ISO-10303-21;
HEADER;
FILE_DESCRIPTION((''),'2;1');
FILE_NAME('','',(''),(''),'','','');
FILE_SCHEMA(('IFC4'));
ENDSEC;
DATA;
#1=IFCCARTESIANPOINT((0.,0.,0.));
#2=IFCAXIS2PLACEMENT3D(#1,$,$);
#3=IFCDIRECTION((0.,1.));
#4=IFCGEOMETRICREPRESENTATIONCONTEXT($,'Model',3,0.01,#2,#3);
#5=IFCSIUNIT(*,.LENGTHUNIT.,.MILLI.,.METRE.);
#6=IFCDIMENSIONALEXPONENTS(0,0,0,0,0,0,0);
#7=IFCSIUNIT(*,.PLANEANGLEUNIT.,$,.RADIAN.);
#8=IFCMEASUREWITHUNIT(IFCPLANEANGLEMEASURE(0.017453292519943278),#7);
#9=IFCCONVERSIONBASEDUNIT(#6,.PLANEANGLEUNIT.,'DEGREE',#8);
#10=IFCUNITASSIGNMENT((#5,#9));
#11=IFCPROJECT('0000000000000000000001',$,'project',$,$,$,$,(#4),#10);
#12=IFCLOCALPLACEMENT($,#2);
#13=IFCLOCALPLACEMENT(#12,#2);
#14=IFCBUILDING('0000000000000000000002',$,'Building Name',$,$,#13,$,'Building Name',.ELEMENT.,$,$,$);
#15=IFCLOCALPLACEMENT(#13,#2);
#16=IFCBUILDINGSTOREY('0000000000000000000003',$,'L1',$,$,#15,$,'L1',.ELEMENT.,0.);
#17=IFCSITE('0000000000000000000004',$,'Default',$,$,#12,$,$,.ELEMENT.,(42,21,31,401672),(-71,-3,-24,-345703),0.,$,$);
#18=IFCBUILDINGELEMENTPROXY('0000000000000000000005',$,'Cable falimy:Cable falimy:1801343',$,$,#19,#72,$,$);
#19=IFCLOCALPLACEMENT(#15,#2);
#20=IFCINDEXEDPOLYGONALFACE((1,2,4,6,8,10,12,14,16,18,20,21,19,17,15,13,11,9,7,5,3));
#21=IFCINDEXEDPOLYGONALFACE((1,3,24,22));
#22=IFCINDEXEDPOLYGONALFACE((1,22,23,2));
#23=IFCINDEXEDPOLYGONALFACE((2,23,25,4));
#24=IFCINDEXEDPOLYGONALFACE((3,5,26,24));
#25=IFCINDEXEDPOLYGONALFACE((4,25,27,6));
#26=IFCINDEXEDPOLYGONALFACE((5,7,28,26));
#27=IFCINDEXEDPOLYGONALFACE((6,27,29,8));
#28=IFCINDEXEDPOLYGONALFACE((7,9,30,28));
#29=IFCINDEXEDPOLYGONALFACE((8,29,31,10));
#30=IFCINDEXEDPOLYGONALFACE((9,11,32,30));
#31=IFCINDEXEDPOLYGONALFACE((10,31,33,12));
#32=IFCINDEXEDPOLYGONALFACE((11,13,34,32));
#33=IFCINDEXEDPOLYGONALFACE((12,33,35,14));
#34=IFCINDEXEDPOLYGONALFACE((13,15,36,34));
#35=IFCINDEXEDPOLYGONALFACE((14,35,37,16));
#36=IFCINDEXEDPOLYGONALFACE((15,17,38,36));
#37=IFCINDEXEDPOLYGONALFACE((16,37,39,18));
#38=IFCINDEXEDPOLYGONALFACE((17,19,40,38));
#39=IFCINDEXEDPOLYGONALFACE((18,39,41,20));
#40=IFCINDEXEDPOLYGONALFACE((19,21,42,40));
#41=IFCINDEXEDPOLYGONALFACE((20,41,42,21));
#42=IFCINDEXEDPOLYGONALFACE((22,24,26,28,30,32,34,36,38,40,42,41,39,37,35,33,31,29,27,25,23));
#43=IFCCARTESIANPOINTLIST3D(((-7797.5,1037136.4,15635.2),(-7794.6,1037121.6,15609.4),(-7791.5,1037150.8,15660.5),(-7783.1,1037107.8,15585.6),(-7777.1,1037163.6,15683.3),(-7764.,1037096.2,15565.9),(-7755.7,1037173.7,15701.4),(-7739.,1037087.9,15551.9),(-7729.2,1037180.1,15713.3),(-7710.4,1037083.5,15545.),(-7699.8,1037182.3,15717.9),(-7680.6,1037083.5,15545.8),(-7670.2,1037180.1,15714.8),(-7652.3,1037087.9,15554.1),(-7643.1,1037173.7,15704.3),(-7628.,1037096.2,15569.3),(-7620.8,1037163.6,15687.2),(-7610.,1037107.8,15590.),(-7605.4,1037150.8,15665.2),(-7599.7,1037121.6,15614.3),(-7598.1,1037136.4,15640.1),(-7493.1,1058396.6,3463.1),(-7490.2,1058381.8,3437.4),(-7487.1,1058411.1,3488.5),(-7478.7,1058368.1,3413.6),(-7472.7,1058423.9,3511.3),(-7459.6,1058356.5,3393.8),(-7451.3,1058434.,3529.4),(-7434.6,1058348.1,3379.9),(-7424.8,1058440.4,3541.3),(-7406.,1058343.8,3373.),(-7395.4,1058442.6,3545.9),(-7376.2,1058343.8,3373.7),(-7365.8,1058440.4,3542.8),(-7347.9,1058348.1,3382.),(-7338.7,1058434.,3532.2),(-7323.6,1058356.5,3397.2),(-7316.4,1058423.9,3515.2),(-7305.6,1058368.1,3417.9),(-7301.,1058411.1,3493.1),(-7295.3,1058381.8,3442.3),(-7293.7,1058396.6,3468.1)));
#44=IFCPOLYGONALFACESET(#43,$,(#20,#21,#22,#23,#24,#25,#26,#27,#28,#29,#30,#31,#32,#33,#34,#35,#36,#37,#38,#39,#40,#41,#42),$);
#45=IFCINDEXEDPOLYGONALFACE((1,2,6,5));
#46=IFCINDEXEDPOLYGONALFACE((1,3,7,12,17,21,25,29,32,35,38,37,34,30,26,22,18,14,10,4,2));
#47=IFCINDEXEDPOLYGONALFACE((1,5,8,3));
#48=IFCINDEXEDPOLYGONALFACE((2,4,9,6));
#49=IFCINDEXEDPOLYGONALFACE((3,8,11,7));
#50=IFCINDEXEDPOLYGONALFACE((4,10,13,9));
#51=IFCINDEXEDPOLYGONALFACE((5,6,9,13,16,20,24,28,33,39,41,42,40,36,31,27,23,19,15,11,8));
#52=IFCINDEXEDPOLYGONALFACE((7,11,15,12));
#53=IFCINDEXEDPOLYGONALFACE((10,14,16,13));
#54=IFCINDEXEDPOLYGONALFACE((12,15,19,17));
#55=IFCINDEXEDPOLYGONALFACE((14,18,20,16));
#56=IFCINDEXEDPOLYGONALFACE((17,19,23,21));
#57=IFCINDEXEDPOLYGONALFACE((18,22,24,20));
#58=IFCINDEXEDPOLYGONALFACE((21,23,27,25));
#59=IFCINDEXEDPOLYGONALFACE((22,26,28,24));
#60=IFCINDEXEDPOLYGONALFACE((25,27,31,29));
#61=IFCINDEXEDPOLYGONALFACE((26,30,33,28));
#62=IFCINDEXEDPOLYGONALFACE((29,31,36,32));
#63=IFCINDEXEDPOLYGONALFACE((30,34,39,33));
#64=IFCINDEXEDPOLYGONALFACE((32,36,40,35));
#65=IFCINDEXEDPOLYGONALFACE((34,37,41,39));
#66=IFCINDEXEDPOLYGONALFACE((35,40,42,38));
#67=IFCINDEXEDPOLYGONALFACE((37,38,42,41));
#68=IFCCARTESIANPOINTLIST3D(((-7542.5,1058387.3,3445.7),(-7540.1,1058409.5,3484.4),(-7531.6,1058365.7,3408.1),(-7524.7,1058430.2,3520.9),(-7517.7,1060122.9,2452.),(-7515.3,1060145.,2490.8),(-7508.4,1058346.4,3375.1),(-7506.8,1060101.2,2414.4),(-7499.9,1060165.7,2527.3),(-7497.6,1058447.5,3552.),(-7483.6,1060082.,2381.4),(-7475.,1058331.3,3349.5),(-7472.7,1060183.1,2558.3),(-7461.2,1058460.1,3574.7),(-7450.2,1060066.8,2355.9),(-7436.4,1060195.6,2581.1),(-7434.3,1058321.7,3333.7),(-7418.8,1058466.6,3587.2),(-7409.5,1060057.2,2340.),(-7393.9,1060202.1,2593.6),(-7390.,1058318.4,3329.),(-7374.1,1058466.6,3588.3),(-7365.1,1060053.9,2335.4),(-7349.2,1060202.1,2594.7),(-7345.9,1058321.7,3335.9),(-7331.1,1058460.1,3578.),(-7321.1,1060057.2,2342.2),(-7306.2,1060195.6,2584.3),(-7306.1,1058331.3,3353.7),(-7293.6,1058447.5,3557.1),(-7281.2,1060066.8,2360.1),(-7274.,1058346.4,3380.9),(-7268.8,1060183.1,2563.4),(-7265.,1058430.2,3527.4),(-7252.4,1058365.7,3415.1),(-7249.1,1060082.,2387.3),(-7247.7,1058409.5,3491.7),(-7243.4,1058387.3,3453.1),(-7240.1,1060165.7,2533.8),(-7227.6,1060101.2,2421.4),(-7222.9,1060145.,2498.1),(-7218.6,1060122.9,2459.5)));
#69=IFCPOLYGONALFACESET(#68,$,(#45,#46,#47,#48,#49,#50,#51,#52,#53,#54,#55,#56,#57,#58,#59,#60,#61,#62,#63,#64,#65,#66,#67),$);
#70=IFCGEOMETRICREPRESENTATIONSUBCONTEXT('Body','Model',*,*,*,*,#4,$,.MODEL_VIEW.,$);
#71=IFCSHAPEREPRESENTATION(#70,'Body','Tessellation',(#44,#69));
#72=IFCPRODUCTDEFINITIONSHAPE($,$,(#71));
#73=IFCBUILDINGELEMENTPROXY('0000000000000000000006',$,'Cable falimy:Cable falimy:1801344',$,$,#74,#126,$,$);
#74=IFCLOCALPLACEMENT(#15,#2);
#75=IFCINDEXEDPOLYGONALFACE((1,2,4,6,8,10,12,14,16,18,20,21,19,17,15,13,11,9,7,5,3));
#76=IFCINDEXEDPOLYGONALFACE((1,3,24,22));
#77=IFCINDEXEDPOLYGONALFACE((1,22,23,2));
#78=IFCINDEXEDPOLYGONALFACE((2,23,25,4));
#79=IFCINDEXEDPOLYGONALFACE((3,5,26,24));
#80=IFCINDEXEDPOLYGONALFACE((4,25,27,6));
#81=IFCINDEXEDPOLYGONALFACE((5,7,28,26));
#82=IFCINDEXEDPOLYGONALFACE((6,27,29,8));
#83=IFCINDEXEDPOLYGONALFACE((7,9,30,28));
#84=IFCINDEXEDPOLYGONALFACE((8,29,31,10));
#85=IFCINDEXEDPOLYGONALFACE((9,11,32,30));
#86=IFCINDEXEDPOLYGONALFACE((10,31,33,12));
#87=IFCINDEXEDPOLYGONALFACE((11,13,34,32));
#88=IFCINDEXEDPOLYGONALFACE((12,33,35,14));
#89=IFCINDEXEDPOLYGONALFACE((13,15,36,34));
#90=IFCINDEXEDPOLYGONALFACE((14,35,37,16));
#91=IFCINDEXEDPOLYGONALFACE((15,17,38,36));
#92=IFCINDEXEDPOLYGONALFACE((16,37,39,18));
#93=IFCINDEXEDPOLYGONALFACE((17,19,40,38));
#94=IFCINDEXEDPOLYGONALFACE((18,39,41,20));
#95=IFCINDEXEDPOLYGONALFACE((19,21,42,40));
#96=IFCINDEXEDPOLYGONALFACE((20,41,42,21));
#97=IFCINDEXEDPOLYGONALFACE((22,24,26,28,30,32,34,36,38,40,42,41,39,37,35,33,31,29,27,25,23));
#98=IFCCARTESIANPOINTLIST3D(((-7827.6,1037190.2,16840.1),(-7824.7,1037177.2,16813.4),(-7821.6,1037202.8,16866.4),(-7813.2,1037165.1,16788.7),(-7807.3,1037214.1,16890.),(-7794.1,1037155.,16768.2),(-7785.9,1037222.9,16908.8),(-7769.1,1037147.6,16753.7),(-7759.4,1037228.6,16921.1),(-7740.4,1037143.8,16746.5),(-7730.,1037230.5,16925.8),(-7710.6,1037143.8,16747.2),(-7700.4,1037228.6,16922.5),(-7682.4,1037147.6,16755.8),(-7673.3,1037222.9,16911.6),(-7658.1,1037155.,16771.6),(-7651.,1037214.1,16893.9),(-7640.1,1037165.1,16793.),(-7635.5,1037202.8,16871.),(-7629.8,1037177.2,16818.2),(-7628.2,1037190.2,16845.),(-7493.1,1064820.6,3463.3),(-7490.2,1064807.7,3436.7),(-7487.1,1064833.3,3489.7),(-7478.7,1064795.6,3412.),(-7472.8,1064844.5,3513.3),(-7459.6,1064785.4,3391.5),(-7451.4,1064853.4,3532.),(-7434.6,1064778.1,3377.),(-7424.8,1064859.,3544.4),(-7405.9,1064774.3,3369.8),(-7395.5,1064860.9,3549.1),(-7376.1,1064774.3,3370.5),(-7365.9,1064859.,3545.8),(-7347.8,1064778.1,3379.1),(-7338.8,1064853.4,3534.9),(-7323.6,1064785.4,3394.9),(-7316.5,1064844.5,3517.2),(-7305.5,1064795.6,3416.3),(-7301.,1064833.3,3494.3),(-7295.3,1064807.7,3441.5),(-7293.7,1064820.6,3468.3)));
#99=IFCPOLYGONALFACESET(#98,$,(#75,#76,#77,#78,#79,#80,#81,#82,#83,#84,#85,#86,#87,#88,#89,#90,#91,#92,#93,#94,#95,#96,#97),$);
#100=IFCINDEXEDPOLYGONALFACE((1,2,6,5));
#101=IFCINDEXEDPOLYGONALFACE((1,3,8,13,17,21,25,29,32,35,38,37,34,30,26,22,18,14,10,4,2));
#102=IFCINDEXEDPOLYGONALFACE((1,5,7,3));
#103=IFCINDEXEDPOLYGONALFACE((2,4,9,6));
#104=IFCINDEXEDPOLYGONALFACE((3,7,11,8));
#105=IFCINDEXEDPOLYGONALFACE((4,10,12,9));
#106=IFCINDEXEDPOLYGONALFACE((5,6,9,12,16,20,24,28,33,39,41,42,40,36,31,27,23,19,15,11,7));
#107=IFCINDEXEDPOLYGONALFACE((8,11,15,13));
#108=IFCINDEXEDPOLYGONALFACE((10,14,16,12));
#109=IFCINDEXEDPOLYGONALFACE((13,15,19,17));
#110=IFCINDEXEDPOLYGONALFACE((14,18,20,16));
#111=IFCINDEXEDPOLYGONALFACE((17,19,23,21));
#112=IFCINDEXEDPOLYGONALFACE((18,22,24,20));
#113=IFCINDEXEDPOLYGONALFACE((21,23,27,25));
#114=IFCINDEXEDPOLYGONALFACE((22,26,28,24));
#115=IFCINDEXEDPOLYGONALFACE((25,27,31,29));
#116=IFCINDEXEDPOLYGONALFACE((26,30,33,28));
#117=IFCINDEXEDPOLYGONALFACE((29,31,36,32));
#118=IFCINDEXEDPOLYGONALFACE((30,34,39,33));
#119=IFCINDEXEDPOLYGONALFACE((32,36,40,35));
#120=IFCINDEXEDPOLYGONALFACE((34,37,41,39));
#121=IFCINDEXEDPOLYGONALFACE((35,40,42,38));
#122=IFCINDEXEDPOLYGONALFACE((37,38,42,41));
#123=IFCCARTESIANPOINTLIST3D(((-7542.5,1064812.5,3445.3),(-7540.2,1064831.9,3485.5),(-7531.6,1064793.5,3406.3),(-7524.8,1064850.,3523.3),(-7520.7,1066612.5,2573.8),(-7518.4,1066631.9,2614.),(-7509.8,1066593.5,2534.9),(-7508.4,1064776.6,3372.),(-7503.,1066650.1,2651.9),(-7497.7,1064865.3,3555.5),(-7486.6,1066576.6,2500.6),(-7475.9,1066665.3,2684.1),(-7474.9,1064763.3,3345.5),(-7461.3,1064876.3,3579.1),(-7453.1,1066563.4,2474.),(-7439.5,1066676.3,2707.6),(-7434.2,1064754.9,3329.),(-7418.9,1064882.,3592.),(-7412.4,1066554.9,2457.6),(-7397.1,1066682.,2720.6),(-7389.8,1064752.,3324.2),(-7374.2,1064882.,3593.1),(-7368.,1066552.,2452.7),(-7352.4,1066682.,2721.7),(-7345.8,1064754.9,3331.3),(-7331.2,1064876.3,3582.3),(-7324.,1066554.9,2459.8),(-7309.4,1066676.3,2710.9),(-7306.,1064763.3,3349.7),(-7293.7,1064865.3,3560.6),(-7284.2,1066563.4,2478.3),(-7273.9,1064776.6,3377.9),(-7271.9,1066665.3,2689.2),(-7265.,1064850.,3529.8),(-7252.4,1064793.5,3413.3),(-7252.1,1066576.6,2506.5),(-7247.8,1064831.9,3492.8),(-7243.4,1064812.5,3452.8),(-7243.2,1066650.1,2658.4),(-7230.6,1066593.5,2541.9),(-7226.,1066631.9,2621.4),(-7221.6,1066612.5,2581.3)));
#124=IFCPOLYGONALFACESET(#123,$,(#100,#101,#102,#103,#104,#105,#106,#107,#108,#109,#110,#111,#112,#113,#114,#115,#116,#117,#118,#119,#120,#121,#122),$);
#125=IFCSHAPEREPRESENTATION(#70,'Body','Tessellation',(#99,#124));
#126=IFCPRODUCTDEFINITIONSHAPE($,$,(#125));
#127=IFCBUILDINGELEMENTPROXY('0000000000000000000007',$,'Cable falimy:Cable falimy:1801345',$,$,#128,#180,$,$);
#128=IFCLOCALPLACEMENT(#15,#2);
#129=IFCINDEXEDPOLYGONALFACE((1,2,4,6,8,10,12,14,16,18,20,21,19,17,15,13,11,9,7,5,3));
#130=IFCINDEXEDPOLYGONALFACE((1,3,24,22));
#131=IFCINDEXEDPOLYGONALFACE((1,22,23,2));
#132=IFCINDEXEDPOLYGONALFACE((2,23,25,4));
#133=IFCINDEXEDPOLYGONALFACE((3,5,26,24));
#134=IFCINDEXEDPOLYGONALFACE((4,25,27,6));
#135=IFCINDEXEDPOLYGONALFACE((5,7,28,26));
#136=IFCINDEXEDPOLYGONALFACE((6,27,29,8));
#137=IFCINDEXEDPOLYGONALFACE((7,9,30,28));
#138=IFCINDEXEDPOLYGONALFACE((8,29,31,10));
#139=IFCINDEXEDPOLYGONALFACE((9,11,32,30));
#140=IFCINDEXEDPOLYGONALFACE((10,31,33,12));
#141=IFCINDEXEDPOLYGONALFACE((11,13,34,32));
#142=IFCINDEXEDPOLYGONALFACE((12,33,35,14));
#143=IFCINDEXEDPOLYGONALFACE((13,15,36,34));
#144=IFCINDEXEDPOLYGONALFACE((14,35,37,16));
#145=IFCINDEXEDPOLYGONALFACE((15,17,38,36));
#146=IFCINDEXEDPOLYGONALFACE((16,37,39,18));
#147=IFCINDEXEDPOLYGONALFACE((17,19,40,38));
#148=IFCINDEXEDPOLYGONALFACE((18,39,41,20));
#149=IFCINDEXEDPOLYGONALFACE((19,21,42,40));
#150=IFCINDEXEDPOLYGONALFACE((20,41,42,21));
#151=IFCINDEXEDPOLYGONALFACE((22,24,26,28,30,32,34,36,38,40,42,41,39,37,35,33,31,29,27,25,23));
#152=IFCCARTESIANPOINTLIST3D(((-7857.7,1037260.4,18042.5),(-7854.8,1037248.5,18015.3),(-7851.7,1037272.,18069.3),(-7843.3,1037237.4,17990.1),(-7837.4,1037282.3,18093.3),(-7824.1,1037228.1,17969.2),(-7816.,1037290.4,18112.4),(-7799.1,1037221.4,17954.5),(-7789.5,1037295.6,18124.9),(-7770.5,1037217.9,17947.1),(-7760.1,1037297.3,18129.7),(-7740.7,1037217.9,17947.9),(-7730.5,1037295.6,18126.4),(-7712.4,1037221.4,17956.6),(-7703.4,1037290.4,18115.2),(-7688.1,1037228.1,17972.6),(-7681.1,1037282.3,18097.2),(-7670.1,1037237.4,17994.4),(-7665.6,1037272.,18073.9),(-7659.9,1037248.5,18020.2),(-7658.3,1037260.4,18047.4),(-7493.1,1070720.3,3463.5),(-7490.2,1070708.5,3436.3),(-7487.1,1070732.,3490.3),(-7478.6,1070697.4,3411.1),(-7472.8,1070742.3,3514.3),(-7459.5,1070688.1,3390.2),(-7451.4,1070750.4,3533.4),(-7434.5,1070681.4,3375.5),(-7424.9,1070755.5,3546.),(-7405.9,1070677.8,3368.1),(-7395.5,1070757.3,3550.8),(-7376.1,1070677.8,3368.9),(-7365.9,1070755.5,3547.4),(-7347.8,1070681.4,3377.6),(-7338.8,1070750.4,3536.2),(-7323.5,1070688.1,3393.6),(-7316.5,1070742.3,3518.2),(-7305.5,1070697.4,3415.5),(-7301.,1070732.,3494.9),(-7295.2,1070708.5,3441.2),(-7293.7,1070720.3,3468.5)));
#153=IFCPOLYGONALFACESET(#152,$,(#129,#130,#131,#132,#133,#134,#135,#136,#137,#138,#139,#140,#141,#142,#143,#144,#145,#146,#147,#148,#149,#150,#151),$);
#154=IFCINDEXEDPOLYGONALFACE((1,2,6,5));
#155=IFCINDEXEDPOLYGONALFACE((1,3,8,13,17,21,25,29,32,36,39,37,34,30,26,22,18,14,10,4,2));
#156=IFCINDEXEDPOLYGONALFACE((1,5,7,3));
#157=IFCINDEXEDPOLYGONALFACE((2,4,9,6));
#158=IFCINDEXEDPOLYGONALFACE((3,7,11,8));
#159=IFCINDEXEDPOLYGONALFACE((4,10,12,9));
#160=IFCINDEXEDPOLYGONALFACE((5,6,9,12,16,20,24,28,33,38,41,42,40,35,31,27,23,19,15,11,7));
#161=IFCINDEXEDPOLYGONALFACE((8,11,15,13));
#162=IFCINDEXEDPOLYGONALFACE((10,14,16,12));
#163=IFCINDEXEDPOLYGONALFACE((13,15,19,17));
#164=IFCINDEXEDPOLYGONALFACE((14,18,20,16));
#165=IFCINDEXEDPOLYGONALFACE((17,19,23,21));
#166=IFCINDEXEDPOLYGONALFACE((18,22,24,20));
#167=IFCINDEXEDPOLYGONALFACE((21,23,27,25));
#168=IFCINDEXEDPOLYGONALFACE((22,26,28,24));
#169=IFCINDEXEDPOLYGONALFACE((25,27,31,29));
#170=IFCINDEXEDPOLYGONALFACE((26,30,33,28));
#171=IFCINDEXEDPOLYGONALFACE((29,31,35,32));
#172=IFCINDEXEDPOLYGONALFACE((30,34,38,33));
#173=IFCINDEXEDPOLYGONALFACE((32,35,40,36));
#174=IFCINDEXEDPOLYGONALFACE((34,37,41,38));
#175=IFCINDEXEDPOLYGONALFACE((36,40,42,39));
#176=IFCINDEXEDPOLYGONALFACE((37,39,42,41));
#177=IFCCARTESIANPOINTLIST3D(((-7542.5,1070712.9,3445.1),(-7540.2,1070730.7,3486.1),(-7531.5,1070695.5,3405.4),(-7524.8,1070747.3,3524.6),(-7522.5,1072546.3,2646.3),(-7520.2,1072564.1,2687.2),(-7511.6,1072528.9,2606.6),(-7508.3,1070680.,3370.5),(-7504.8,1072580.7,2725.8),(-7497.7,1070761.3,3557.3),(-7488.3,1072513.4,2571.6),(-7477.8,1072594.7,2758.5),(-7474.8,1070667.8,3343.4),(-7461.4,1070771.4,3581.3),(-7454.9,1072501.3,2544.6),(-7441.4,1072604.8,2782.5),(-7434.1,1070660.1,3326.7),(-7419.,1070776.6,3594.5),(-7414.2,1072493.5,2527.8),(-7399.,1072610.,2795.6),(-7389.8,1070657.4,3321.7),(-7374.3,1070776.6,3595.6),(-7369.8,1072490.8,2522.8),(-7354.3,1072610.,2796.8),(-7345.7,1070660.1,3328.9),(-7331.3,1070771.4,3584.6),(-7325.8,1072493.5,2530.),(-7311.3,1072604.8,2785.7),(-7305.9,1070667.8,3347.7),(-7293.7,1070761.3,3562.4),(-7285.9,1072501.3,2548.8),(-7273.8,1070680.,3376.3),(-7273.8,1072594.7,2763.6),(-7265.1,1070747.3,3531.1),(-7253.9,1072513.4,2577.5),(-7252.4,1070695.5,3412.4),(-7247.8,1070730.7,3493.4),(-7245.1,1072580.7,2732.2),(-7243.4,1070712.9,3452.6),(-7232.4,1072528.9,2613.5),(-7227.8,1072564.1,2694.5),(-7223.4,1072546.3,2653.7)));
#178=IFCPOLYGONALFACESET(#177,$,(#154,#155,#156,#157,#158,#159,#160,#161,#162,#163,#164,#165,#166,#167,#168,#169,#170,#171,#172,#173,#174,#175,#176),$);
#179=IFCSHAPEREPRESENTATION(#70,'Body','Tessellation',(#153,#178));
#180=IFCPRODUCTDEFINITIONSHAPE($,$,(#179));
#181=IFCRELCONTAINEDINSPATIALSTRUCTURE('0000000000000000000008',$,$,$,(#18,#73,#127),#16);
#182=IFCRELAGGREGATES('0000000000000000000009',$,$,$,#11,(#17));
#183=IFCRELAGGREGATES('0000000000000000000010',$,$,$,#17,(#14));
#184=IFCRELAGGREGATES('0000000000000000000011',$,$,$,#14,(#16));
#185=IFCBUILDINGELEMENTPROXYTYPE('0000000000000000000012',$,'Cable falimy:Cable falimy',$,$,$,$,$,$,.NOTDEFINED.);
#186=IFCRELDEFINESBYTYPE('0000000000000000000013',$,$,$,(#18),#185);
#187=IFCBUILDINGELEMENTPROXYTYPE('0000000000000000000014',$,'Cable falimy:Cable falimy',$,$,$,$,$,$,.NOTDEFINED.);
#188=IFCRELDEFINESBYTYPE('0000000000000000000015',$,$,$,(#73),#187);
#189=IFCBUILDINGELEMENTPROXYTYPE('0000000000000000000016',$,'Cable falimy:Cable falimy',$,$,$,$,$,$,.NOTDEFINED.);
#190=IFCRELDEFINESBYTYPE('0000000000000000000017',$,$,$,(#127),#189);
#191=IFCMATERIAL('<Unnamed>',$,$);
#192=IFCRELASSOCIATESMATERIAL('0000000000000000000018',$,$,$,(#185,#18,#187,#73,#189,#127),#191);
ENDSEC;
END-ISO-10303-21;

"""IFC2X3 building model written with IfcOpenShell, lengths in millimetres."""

from ifc_helpers import new_model, entity, si_unit, converted_unit, direction, frame, frame_2d, origin, place, context, subcontext, project, spatial, circle, extrude, source, transform, mapped, material, type_object, type_shapes, element, save


model = new_model("IFC2X3")

# Units and contexts
model_context = context("Model", 3, precision=0.01, world=origin(), true_north=direction((0.0, 1.0)))
body_context = subcontext(model_context, "Body", "Model", "MODEL_VIEW")
ifc_project = project(units=[si_unit("LENGTHUNIT", "METRE", prefix="MILLI"), converted_unit("PLANEANGLEUNIT", "DEGREE", entity("IfcPlaneAngleMeasure", 0.017453292519943278), si_unit("PLANEANGLEUNIT", "RADIAN"), dimensions=[0, 0, 0, 0, 0, 0, 0])], contexts=[model_context])

# Site, building, storey
site_placement = place(None, origin())
site = spatial("IfcSite", under=ifc_project, at=site_placement, Name="Default", CompositionType="ELEMENT", RefLatitude=(42, 21, 31, 401672), RefLongitude=(-71, -3, -24, -345703), RefElevation=0.0)
building_placement = place(site_placement, origin())
building = spatial("IfcBuilding", under=site, at=building_placement, Name="Building Name", LongName="Building Name", CompositionType="ELEMENT")
storey_placement = place(building_placement, origin())
storey = spatial("IfcBuildingStorey", under=building, at=storey_placement, Name="L1", LongName="L1", CompositionType="ELEMENT", Elevation=0.0)

# Shared definitions
ifc_material = material(Name="<Unnamed>")

# Building element proxies
building_element_proxy_type_1 = type_object("IfcBuildingElementProxyType", Name="Cable falimy:Cable falimy", PredefinedType="NOTDEFINED", material=ifc_material)
shared_shape_1 = source(origin(), body_context, "Body", "SweptSolid", [
    extrude(circle(Radius=100.0, at=frame_2d((0.0, 0.0), x_axis=(1.0, 0.0))), frame((0.0, 0.0, 0.0), z_axis=(0.867765, 0.0, 0.496974), x_axis=(-0.496974, 0.0, 0.867765)), (0.0, 0.0, 1.0), 24500.0),
    extrude(circle(Radius=150.0, at=frame_2d((0.0, 0.0), x_axis=(1.0, 0.0))), frame((-1735.5, 0.0, -993.9), z_axis=(0.867765, 0.0, 0.496974), x_axis=(0.496974, 0.0, -0.867765)), (0.0, 0.0, 1.0), 2000.0),
])
type_shapes(building_element_proxy_type_1, [shared_shape_1])
proxy_1_placement = place(storey_placement, frame((-7393.2, 1058392.9, 3459.1), z_axis=(-0.025001, 0.0, 0.999687), x_axis=(0.0, -1.0, 0.0)))
element("IfcBuildingElementProxy", 1, at=proxy_1_placement, inside=storey, type_object=building_element_proxy_type_1, material=ifc_material, Name="Cable falimy:Cable falimy:1801343", context=body_context, shape_type="MappedRepresentation", body=[
    mapped(shared_shape_1, transform((0.0, 0.0, 0.0), scale=1.0)),
])
building_element_proxy_type_2 = type_object("IfcBuildingElementProxyType", Name="Cable falimy:Cable falimy", PredefinedType="NOTDEFINED", material=ifc_material)
shared_shape_2 = source(origin(), body_context, "Body", "SweptSolid", [
    extrude(circle(Radius=100.0, at=frame_2d((0.0, 0.0), x_axis=(1.0, 0.0))), frame((0.0, 0.0, 0.0), z_axis=(0.900015, 0.0, 0.43586), x_axis=(-0.43586, 0.0, 0.900015)), (0.0, 0.0, 1.0), 30700.0),
    extrude(circle(Radius=150.0, at=frame_2d((0.0, 0.0), x_axis=(1.0, 0.0))), frame((-1800.0, 0.0, -871.7), z_axis=(0.900015, 0.0, 0.43586), x_axis=(0.43586, 0.0, -0.900015)), (0.0, 0.0, 1.0), 2000.0),
])
type_shapes(building_element_proxy_type_2, [shared_shape_2])
proxy_2_placement = place(storey_placement, frame((-7393.2, 1064817.4, 3459.1), z_axis=(-0.025001, 0.0, 0.999687), x_axis=(0.0, -1.0, 0.0)))
element("IfcBuildingElementProxy", 2, at=proxy_2_placement, inside=storey, type_object=building_element_proxy_type_2, material=ifc_material, Name="Cable falimy:Cable falimy:1801344", context=body_context, shape_type="MappedRepresentation", body=[
    mapped(shared_shape_2, transform((0.0, 0.0, 0.0), scale=1.0)),
])
building_element_proxy_type_3 = type_object("IfcBuildingElementProxyType", Name="Cable falimy:Cable falimy", PredefinedType="NOTDEFINED", material=ifc_material)
shared_shape_3 = source(origin(), body_context, "Body", "SweptSolid", [
    extrude(circle(Radius=100.0, at=frame_2d((0.0, 0.0), x_axis=(1.0, 0.0))), frame((0.0, 0.0, 0.0), z_axis=(0.916712, 0.0, 0.399549), x_axis=(-0.399549, 0.0, 0.916712)), (0.0, 0.0, 1.0), 36500.0),
    extrude(circle(Radius=150.0, at=frame_2d((0.0, 0.0), x_axis=(1.0, 0.0))), frame((-1833.4, 0.0, -799.1), z_axis=(0.916712, 0.0, 0.399549), x_axis=(0.399549, 0.0, -0.916712)), (0.0, 0.0, 1.0), 2000.0),
])
type_shapes(building_element_proxy_type_3, [shared_shape_3])
proxy_3_placement = place(storey_placement, frame((-7393.2, 1070717.4, 3459.1), z_axis=(-0.025001, 0.0, 0.999687), x_axis=(0.0, -1.0, 0.0)))
element("IfcBuildingElementProxy", 3, at=proxy_3_placement, inside=storey, type_object=building_element_proxy_type_3, material=ifc_material, Name="Cable falimy:Cable falimy:1801345", context=body_context, shape_type="MappedRepresentation", body=[
    mapped(shared_shape_3, transform((0.0, 0.0, 0.0), scale=1.0)),
])

save(model, "model.ifc")
